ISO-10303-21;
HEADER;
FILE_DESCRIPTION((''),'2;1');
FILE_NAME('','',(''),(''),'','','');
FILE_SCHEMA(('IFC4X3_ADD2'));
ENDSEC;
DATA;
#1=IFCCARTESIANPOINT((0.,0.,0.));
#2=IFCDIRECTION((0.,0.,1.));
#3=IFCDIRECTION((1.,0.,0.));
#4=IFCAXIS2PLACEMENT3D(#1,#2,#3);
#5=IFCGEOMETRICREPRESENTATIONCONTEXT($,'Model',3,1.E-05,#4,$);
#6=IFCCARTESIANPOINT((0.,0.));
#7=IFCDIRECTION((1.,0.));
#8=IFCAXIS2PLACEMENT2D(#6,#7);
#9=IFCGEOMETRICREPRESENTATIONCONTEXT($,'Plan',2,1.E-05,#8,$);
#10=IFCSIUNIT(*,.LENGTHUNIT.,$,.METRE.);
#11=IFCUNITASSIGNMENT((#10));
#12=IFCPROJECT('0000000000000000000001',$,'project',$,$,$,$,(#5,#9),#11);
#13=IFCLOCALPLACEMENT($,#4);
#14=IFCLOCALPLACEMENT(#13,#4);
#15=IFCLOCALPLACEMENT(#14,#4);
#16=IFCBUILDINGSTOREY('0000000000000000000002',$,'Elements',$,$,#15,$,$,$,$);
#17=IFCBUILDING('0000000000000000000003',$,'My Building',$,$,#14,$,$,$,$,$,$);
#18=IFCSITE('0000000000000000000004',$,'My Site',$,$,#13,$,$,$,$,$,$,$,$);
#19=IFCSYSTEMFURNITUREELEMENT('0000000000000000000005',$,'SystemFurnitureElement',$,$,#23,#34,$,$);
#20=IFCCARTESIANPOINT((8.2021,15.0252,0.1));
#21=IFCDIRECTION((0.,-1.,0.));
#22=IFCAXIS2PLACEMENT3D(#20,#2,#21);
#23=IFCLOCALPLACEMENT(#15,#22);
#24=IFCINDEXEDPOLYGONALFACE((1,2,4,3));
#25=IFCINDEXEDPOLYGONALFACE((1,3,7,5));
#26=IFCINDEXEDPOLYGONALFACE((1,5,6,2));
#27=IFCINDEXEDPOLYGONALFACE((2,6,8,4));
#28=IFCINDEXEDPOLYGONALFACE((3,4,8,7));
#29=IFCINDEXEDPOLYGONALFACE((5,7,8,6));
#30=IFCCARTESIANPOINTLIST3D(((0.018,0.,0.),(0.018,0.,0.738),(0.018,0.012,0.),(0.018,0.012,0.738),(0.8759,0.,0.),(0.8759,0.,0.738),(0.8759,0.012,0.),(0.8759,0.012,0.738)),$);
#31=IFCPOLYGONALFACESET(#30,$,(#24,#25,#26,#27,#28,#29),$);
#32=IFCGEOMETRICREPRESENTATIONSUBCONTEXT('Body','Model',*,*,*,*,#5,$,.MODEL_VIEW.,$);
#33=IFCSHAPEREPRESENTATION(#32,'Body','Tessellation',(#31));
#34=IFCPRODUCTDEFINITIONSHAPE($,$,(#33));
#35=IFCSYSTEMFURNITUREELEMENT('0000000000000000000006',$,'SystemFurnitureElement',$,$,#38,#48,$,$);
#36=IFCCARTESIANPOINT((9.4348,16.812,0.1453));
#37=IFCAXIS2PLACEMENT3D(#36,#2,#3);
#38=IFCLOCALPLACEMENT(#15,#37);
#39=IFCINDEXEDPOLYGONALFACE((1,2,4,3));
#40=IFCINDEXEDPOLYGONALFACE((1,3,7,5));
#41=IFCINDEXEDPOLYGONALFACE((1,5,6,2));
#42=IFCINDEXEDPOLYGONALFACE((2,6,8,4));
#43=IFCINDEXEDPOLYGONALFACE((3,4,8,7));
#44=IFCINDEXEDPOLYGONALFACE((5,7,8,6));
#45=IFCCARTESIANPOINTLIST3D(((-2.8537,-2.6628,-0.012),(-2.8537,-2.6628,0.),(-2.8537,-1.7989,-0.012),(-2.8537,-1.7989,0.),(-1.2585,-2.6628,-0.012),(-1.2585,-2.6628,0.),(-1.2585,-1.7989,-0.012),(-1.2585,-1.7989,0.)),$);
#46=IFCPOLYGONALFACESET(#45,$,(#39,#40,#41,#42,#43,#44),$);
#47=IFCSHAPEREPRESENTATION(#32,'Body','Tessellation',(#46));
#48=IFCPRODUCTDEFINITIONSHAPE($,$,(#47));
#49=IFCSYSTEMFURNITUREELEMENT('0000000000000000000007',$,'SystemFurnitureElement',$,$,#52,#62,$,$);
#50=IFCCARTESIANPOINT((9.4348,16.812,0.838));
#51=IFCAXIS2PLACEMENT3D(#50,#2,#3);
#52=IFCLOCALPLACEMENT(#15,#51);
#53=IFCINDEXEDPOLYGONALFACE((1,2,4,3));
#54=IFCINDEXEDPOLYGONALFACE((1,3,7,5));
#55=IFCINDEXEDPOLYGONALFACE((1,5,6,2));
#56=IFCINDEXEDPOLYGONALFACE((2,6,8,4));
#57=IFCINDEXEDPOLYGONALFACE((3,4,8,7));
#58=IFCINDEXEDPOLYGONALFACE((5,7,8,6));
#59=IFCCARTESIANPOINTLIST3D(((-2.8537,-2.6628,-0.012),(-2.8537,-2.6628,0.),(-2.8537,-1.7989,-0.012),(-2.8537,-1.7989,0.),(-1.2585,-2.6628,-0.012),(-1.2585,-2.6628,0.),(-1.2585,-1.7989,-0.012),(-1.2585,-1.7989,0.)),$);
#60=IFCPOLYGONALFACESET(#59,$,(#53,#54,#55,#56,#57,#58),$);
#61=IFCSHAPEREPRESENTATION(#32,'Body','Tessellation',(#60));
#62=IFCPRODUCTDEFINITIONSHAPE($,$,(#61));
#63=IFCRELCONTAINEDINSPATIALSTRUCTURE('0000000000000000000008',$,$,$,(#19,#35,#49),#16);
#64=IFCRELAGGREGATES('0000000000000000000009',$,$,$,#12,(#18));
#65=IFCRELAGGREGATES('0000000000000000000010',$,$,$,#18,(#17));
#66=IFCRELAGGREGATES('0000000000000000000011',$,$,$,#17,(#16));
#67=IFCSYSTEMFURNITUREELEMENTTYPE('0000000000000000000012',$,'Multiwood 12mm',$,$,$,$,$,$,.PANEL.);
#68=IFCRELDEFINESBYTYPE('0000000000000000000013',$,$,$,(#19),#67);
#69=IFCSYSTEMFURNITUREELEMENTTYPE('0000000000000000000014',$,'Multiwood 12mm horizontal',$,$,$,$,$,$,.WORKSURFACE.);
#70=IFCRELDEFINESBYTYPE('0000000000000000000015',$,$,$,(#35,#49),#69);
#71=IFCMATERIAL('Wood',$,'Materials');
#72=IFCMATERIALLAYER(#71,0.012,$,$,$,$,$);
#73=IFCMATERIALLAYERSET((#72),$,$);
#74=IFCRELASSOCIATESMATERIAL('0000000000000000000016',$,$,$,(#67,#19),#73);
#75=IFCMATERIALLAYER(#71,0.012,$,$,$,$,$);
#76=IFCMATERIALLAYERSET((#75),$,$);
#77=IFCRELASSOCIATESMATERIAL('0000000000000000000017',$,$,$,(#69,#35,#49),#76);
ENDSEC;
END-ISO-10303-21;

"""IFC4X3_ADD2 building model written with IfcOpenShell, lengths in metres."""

from ifc_helpers import new_model, si_unit, frame, origin_with_axes, origin_2d_with_axis, place, context, subcontext, project, spatial, line, indexed_curve, outline, extrude, material, layer, layer_set, layer_usage, type_object, element, save


model = new_model("IFC4X3_ADD2")

# Units and contexts
model_context = context("Model", 3, precision=1e-05, world=origin_with_axes())
plan_context = context("Plan", 2, precision=1e-05, world=origin_2d_with_axis())
body_context = subcontext(model_context, "Body", "Model", "MODEL_VIEW")
ifc_project = project(units=[si_unit("LENGTHUNIT", "METRE")], contexts=[model_context, plan_context])

# Site, building, storey
site_placement = place(None, origin_with_axes())
site = spatial("IfcSite", under=ifc_project, at=site_placement, Name="My Site")
building_placement = place(site_placement, origin_with_axes())
building = spatial("IfcBuilding", under=site, at=building_placement, Name="My Building")
storey_placement = place(building_placement, origin_with_axes())
storey = spatial("IfcBuildingStorey", under=building, at=storey_placement, Name="Elements")

# System furniture element
ifc_material_1 = material(Name="Wood", Category="Materials")
ifc_layer_1 = layer(ifc_material_1, 0.012)
ifc_layer_set_1 = layer_set([ifc_layer_1])
ifc_layer_usage_1 = layer_usage(ifc_layer_set_1, "AXIS2", "POSITIVE", 0.0)
system_furniture_element_type_1 = type_object("IfcSystemFurnitureElementType", Name="Multiwood 12mm", PredefinedType="PANEL", material=ifc_layer_set_1)
system_furniture_element_1_placement = place(storey_placement, frame((8.2021, 15.0252, 0.1), z_axis=(0.0, 0.0, 1.0), x_axis=(0.0, -1.0, 0.0)))
element("IfcSystemFurnitureElement", 1, at=system_furniture_element_1_placement, inside=storey, type_object=system_furniture_element_type_1, material=ifc_layer_usage_1, Name="SystemFurnitureElement", context=body_context, shape_type="SweptSolid", body=[
    extrude(outline(indexed_curve([(0.018, 0.0), (0.018, 0.012), (0.8759, 0.012), (0.8759, 0.0)], segments=[line(1, 2, 3, 4, 1)])), origin_with_axes(), (0.0, 0.0, 1.0), 0.738),
])

# System furniture elements
ifc_layer_2 = layer(ifc_material_1, 0.012)
ifc_layer_set_2 = layer_set([ifc_layer_2])
ifc_layer_usage_2 = layer_usage(ifc_layer_set_2, "AXIS3", "POSITIVE", -0.012)
system_furniture_element_type_2 = type_object("IfcSystemFurnitureElementType", Name="Multiwood 12mm horizontal", PredefinedType="WORKSURFACE", material=ifc_layer_set_2)
system_furniture_element_2_placement = place(storey_placement, frame((9.4348, 16.812, 0.1453), z_axis=(0.0, 0.0, 1.0), x_axis=(1.0, 0.0, 0.0)))
element("IfcSystemFurnitureElement", 2, at=system_furniture_element_2_placement, inside=storey, type_object=system_furniture_element_type_2, material=ifc_layer_usage_2, Name="SystemFurnitureElement", context=body_context, shape_type="SweptSolid", body=[
    extrude(outline(indexed_curve([(-1.2585, -1.7989), (-1.2585, -2.6628), (-2.8537, -2.6628), (-2.8537, -1.7989), (-1.2585, -1.7989)])), frame((0.0, 0.0, -0.012), z_axis=(0.0, 0.0, 1.0), x_axis=(1.0, 0.0, 0.0)), (0.0, 0.0, 1.0), 0.012),
])
ifc_layer_usage_3 = layer_usage(ifc_layer_set_2, "AXIS3", "POSITIVE", -0.012)
system_furniture_element_3_placement = place(storey_placement, frame((9.4348, 16.812, 0.838), z_axis=(0.0, 0.0, 1.0), x_axis=(1.0, 0.0, 0.0)))
element("IfcSystemFurnitureElement", 3, at=system_furniture_element_3_placement, inside=storey, type_object=system_furniture_element_type_2, material=ifc_layer_usage_3, Name="SystemFurnitureElement", context=body_context, shape_type="SweptSolid", body=[
    extrude(outline(indexed_curve([(-1.2585, -1.7989), (-1.2585, -2.6628), (-2.8537, -2.6628), (-2.8537, -1.7989), (-1.2585, -1.7989)])), frame((0.0, 0.0, -0.012), z_axis=(0.0, 0.0, 1.0), x_axis=(1.0, 0.0, 0.0)), (0.0, 0.0, 1.0), 0.012),
])

save(model, "model.ifc")
